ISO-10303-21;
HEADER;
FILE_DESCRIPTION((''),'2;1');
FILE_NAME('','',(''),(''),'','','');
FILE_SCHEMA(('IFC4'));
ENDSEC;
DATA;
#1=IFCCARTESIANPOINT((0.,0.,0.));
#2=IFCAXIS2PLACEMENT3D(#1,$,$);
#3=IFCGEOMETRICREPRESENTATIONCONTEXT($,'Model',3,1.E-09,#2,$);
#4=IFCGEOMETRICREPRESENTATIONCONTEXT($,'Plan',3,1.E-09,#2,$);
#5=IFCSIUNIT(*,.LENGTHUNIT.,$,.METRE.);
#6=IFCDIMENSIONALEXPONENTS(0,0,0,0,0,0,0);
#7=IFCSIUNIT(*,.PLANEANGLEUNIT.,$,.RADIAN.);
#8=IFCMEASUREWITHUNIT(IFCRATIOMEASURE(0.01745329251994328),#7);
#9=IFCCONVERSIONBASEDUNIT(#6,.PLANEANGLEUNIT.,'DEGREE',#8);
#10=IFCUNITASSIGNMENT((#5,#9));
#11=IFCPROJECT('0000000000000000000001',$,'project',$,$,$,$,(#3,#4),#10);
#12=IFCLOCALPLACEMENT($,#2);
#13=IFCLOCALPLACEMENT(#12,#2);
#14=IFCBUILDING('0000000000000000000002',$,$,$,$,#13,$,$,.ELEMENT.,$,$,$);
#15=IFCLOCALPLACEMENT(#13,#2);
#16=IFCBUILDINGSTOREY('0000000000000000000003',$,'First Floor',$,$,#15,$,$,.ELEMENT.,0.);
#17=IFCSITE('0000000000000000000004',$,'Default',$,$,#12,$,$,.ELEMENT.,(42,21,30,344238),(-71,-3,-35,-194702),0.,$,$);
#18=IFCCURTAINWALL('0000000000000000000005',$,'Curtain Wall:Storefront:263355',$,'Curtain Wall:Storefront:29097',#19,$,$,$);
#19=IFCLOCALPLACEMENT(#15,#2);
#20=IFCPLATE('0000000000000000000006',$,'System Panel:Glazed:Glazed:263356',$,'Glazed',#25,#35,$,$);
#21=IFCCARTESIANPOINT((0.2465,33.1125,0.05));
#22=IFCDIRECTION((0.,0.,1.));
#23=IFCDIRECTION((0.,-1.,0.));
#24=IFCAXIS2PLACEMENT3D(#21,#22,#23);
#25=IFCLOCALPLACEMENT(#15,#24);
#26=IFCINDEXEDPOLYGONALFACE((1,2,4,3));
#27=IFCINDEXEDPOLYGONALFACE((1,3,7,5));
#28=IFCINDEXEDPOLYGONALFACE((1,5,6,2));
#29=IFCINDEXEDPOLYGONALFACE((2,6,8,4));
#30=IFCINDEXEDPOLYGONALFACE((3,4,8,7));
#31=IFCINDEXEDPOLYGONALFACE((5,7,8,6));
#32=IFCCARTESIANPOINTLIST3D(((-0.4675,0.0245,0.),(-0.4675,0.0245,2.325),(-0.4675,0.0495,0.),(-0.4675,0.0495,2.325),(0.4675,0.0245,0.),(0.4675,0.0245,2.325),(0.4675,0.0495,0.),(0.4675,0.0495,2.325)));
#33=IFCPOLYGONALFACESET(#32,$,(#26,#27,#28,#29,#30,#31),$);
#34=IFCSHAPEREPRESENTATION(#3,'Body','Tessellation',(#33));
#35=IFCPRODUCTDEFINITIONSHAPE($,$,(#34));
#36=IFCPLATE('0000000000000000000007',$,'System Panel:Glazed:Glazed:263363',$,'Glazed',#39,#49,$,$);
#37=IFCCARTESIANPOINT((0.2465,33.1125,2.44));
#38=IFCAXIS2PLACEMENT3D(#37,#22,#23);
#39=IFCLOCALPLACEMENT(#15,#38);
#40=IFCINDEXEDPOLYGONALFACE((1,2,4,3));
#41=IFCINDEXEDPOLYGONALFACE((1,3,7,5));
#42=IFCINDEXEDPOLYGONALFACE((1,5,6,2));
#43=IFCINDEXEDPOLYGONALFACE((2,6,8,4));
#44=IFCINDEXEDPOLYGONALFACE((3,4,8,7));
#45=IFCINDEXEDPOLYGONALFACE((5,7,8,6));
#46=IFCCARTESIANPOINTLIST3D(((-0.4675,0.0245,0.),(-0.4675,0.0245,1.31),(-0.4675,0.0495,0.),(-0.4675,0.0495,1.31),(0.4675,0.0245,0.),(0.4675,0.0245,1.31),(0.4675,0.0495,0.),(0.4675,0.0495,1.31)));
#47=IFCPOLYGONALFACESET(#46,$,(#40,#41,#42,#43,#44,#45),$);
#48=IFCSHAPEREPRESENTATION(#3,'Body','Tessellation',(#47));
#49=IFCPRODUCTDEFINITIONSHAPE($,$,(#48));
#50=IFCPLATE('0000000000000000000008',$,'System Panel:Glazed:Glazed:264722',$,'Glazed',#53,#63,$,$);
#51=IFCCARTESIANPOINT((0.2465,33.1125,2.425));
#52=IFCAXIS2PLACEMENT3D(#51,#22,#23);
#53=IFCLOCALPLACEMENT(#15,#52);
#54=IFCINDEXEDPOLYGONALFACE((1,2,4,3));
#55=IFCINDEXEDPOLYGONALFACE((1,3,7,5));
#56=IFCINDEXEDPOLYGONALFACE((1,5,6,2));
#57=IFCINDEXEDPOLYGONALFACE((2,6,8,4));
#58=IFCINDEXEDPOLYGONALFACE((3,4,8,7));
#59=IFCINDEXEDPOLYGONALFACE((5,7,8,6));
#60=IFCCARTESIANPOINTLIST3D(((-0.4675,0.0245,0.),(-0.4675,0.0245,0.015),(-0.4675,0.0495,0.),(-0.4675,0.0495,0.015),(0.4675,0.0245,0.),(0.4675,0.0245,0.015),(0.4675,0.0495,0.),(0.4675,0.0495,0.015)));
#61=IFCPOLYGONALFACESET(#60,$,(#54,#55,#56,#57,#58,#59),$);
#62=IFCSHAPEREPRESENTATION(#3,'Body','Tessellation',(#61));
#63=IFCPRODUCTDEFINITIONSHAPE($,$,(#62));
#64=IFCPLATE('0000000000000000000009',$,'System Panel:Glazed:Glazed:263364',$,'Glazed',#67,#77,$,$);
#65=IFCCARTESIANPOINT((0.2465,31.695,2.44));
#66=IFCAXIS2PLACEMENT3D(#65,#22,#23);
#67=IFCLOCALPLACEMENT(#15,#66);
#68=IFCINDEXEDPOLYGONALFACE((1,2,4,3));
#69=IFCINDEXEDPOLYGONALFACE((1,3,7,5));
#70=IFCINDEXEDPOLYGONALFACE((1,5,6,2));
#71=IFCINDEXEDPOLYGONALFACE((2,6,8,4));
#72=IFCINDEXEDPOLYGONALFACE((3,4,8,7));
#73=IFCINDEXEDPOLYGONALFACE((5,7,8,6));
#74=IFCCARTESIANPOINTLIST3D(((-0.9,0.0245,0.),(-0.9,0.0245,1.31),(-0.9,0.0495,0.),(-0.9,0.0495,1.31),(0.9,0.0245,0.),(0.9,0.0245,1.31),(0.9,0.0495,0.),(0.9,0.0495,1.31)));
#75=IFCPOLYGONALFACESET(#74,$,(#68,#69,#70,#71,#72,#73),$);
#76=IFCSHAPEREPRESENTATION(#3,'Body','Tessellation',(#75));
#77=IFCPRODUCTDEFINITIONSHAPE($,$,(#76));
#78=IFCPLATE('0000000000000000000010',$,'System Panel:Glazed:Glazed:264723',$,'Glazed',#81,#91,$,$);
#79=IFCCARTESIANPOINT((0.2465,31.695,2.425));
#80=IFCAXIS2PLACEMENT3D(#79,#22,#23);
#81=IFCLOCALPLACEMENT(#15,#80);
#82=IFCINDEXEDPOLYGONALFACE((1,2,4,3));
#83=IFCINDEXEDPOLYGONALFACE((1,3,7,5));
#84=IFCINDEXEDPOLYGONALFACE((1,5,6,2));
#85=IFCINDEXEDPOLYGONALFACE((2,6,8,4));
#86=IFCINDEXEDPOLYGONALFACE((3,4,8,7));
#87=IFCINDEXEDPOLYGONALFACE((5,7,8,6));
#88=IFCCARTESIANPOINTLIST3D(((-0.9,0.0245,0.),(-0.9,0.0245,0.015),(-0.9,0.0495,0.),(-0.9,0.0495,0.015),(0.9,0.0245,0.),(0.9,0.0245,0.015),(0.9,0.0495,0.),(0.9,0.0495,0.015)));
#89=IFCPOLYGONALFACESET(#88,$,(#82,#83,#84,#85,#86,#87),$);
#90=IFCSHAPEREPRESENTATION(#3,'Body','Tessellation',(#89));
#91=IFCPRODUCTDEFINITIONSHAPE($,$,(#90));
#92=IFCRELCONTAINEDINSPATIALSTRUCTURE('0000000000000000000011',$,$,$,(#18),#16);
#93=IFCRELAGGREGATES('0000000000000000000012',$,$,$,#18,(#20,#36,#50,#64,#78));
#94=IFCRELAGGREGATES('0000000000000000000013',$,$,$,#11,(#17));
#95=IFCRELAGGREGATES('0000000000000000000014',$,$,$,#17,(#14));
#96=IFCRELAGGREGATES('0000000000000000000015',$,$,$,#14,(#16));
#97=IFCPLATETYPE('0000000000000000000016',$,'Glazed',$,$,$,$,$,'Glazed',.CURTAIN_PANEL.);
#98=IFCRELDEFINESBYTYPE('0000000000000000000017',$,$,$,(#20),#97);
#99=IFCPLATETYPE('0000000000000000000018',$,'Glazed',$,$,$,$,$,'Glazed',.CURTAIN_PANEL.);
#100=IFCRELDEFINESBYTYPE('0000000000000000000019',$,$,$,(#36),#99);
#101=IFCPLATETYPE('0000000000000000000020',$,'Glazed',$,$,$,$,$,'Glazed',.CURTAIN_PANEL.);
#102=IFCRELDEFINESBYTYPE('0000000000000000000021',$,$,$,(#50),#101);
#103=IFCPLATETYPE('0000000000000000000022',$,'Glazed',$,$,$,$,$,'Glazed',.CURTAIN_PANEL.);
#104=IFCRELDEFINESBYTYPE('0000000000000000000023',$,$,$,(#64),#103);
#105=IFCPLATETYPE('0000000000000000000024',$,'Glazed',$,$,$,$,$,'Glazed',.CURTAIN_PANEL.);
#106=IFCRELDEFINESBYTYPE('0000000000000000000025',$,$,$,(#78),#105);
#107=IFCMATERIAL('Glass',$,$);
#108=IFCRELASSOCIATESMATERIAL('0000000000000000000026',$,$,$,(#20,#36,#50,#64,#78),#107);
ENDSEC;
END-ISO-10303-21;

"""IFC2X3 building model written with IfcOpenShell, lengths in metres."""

from ifc_helpers import new_model, entity, si_unit, converted_unit, frame, origin, origin_2d_with_axis, place, context, project, spatial, rectangle, extrude, source, transform, mapped, material, type_object, type_shapes, element, aggregate, save


model = new_model("IFC2X3")

# Units and contexts
model_context = context("Model", 3, precision=1e-09, world=origin())
plan_context = context("Plan", 3, precision=1e-09, world=origin())
ifc_project = project(units=[si_unit("LENGTHUNIT", "METRE"), converted_unit("PLANEANGLEUNIT", "DEGREE", entity("IfcRatioMeasure", 0.01745329251994328), si_unit("PLANEANGLEUNIT", "RADIAN"), dimensions=[0, 0, 0, 0, 0, 0, 0])], contexts=[model_context, plan_context])

# Site, building, storey
site_placement = place(None, origin())
site = spatial("IfcSite", under=ifc_project, at=site_placement, Name="Default", CompositionType="ELEMENT", RefLatitude=(42, 21, 30, 344238), RefLongitude=(-71, -3, -35, -194702), RefElevation=0.0)
building_placement = place(site_placement, origin())
building = spatial("IfcBuilding", under=site, at=building_placement, CompositionType="ELEMENT")
storey_placement = place(building_placement, origin())
storey = spatial("IfcBuildingStorey", under=building, at=storey_placement, Name="First Floor", CompositionType="ELEMENT", Elevation=0.0)

# Curtain wall, plates
curtain_wall_placement = place(storey_placement, origin())
curtain_wall = element("IfcCurtainWall", 1, at=curtain_wall_placement, inside=storey, Name="Curtain Wall:Storefront:263355", ObjectType="Curtain Wall:Storefront:29097")
ifc_material_1 = material(Name="Glass")
plate_type_1 = type_object("IfcPlateType", Name="Glazed", ElementType="Glazed", PredefinedType="CURTAIN_PANEL")
shared_shape_1 = source(origin(), model_context, "Body", "SweptSolid", [
    extrude(rectangle(XDim=0.025, YDim=0.935, at=origin_2d_with_axis()), frame((0.0, 0.037, 0.0), z_axis=(0.0, 0.0, 1.0), x_axis=(0.0, 1.0, 0.0)), (0.0, 0.0, 1.0), 2.325),
])
type_shapes(plate_type_1, [shared_shape_1])
plate_1_placement = place(storey_placement, frame((0.2465, 33.1125, 0.05), z_axis=(0.0, 0.0, 1.0), x_axis=(0.0, -1.0, 0.0)))
plate_1 = element("IfcPlate", 2, at=plate_1_placement, type_object=plate_type_1, material=ifc_material_1, Name="System Panel:Glazed:Glazed:263356", ObjectType="Glazed", context=model_context, shape_type="MappedRepresentation", body=[
    mapped(shared_shape_1, transform((0.0, 0.0, 0.0), scale=1.0)),
])
plate_type_2 = type_object("IfcPlateType", Name="Glazed", ElementType="Glazed", PredefinedType="CURTAIN_PANEL")
shared_shape_2 = source(origin(), model_context, "Body", "SweptSolid", [
    extrude(rectangle(XDim=0.025, YDim=0.935, at=origin_2d_with_axis()), frame((0.0, 0.037, 0.0), z_axis=(0.0, 0.0, 1.0), x_axis=(0.0, 1.0, 0.0)), (0.0, 0.0, 1.0), 1.31),
])
type_shapes(plate_type_2, [shared_shape_2])
plate_2_placement = place(storey_placement, frame((0.2465, 33.1125, 2.44), z_axis=(0.0, 0.0, 1.0), x_axis=(0.0, -1.0, 0.0)))
plate_2 = element("IfcPlate", 3, at=plate_2_placement, type_object=plate_type_2, material=ifc_material_1, Name="System Panel:Glazed:Glazed:263363", ObjectType="Glazed", context=model_context, shape_type="MappedRepresentation", body=[
    mapped(shared_shape_2, transform((0.0, 0.0, 0.0), scale=1.0)),
])
plate_type_3 = type_object("IfcPlateType", Name="Glazed", ElementType="Glazed", PredefinedType="CURTAIN_PANEL")
shared_shape_3 = source(origin(), model_context, "Body", "SweptSolid", [
    extrude(rectangle(XDim=0.025, YDim=0.935, at=origin_2d_with_axis()), frame((0.0, 0.037, 0.0), z_axis=(0.0, 0.0, 1.0), x_axis=(0.0, 1.0, 0.0)), (0.0, 0.0, 1.0), 0.015),
])
type_shapes(plate_type_3, [shared_shape_3])
plate_3_placement = place(storey_placement, frame((0.2465, 33.1125, 2.425), z_axis=(0.0, 0.0, 1.0), x_axis=(0.0, -1.0, 0.0)))
plate_3 = element("IfcPlate", 4, at=plate_3_placement, type_object=plate_type_3, material=ifc_material_1, Name="System Panel:Glazed:Glazed:264722", ObjectType="Glazed", context=model_context, shape_type="MappedRepresentation", body=[
    mapped(shared_shape_3, transform((0.0, 0.0, 0.0), scale=1.0)),
])
plate_type_4 = type_object("IfcPlateType", Name="Glazed", ElementType="Glazed", PredefinedType="CURTAIN_PANEL")
shared_shape_4 = source(origin(), model_context, "Body", "SweptSolid", [
    extrude(rectangle(XDim=0.025, YDim=1.8, at=origin_2d_with_axis()), frame((0.0, 0.037, 0.0), z_axis=(0.0, 0.0, 1.0), x_axis=(0.0, 1.0, 0.0)), (0.0, 0.0, 1.0), 1.31),
])
type_shapes(plate_type_4, [shared_shape_4])
plate_4_placement = place(storey_placement, frame((0.2465, 31.695, 2.44), z_axis=(0.0, 0.0, 1.0), x_axis=(0.0, -1.0, 0.0)))
plate_4 = element("IfcPlate", 5, at=plate_4_placement, type_object=plate_type_4, material=ifc_material_1, Name="System Panel:Glazed:Glazed:263364", ObjectType="Glazed", context=model_context, shape_type="MappedRepresentation", body=[
    mapped(shared_shape_4, transform((0.0, 0.0, 0.0), scale=1.0)),
])
plate_type_5 = type_object("IfcPlateType", Name="Glazed", ElementType="Glazed", PredefinedType="CURTAIN_PANEL")
shared_shape_5 = source(origin(), model_context, "Body", "SweptSolid", [
    extrude(rectangle(XDim=0.025, YDim=1.8, at=origin_2d_with_axis()), frame((0.0, 0.037, 0.0), z_axis=(0.0, 0.0, 1.0), x_axis=(0.0, 1.0, 0.0)), (0.0, 0.0, 1.0), 0.015),
])
type_shapes(plate_type_5, [shared_shape_5])
plate_5_placement = place(storey_placement, frame((0.2465, 31.695, 2.425), z_axis=(0.0, 0.0, 1.0), x_axis=(0.0, -1.0, 0.0)))
plate_5 = element("IfcPlate", 6, at=plate_5_placement, type_object=plate_type_5, material=ifc_material_1, Name="System Panel:Glazed:Glazed:264723", ObjectType="Glazed", context=model_context, shape_type="MappedRepresentation", body=[
    mapped(shared_shape_5, transform((0.0, 0.0, 0.0), scale=1.0)),
])
aggregate(curtain_wall, [plate_1, plate_2, plate_3, plate_4, plate_5])

save(model, "model.ifc")
